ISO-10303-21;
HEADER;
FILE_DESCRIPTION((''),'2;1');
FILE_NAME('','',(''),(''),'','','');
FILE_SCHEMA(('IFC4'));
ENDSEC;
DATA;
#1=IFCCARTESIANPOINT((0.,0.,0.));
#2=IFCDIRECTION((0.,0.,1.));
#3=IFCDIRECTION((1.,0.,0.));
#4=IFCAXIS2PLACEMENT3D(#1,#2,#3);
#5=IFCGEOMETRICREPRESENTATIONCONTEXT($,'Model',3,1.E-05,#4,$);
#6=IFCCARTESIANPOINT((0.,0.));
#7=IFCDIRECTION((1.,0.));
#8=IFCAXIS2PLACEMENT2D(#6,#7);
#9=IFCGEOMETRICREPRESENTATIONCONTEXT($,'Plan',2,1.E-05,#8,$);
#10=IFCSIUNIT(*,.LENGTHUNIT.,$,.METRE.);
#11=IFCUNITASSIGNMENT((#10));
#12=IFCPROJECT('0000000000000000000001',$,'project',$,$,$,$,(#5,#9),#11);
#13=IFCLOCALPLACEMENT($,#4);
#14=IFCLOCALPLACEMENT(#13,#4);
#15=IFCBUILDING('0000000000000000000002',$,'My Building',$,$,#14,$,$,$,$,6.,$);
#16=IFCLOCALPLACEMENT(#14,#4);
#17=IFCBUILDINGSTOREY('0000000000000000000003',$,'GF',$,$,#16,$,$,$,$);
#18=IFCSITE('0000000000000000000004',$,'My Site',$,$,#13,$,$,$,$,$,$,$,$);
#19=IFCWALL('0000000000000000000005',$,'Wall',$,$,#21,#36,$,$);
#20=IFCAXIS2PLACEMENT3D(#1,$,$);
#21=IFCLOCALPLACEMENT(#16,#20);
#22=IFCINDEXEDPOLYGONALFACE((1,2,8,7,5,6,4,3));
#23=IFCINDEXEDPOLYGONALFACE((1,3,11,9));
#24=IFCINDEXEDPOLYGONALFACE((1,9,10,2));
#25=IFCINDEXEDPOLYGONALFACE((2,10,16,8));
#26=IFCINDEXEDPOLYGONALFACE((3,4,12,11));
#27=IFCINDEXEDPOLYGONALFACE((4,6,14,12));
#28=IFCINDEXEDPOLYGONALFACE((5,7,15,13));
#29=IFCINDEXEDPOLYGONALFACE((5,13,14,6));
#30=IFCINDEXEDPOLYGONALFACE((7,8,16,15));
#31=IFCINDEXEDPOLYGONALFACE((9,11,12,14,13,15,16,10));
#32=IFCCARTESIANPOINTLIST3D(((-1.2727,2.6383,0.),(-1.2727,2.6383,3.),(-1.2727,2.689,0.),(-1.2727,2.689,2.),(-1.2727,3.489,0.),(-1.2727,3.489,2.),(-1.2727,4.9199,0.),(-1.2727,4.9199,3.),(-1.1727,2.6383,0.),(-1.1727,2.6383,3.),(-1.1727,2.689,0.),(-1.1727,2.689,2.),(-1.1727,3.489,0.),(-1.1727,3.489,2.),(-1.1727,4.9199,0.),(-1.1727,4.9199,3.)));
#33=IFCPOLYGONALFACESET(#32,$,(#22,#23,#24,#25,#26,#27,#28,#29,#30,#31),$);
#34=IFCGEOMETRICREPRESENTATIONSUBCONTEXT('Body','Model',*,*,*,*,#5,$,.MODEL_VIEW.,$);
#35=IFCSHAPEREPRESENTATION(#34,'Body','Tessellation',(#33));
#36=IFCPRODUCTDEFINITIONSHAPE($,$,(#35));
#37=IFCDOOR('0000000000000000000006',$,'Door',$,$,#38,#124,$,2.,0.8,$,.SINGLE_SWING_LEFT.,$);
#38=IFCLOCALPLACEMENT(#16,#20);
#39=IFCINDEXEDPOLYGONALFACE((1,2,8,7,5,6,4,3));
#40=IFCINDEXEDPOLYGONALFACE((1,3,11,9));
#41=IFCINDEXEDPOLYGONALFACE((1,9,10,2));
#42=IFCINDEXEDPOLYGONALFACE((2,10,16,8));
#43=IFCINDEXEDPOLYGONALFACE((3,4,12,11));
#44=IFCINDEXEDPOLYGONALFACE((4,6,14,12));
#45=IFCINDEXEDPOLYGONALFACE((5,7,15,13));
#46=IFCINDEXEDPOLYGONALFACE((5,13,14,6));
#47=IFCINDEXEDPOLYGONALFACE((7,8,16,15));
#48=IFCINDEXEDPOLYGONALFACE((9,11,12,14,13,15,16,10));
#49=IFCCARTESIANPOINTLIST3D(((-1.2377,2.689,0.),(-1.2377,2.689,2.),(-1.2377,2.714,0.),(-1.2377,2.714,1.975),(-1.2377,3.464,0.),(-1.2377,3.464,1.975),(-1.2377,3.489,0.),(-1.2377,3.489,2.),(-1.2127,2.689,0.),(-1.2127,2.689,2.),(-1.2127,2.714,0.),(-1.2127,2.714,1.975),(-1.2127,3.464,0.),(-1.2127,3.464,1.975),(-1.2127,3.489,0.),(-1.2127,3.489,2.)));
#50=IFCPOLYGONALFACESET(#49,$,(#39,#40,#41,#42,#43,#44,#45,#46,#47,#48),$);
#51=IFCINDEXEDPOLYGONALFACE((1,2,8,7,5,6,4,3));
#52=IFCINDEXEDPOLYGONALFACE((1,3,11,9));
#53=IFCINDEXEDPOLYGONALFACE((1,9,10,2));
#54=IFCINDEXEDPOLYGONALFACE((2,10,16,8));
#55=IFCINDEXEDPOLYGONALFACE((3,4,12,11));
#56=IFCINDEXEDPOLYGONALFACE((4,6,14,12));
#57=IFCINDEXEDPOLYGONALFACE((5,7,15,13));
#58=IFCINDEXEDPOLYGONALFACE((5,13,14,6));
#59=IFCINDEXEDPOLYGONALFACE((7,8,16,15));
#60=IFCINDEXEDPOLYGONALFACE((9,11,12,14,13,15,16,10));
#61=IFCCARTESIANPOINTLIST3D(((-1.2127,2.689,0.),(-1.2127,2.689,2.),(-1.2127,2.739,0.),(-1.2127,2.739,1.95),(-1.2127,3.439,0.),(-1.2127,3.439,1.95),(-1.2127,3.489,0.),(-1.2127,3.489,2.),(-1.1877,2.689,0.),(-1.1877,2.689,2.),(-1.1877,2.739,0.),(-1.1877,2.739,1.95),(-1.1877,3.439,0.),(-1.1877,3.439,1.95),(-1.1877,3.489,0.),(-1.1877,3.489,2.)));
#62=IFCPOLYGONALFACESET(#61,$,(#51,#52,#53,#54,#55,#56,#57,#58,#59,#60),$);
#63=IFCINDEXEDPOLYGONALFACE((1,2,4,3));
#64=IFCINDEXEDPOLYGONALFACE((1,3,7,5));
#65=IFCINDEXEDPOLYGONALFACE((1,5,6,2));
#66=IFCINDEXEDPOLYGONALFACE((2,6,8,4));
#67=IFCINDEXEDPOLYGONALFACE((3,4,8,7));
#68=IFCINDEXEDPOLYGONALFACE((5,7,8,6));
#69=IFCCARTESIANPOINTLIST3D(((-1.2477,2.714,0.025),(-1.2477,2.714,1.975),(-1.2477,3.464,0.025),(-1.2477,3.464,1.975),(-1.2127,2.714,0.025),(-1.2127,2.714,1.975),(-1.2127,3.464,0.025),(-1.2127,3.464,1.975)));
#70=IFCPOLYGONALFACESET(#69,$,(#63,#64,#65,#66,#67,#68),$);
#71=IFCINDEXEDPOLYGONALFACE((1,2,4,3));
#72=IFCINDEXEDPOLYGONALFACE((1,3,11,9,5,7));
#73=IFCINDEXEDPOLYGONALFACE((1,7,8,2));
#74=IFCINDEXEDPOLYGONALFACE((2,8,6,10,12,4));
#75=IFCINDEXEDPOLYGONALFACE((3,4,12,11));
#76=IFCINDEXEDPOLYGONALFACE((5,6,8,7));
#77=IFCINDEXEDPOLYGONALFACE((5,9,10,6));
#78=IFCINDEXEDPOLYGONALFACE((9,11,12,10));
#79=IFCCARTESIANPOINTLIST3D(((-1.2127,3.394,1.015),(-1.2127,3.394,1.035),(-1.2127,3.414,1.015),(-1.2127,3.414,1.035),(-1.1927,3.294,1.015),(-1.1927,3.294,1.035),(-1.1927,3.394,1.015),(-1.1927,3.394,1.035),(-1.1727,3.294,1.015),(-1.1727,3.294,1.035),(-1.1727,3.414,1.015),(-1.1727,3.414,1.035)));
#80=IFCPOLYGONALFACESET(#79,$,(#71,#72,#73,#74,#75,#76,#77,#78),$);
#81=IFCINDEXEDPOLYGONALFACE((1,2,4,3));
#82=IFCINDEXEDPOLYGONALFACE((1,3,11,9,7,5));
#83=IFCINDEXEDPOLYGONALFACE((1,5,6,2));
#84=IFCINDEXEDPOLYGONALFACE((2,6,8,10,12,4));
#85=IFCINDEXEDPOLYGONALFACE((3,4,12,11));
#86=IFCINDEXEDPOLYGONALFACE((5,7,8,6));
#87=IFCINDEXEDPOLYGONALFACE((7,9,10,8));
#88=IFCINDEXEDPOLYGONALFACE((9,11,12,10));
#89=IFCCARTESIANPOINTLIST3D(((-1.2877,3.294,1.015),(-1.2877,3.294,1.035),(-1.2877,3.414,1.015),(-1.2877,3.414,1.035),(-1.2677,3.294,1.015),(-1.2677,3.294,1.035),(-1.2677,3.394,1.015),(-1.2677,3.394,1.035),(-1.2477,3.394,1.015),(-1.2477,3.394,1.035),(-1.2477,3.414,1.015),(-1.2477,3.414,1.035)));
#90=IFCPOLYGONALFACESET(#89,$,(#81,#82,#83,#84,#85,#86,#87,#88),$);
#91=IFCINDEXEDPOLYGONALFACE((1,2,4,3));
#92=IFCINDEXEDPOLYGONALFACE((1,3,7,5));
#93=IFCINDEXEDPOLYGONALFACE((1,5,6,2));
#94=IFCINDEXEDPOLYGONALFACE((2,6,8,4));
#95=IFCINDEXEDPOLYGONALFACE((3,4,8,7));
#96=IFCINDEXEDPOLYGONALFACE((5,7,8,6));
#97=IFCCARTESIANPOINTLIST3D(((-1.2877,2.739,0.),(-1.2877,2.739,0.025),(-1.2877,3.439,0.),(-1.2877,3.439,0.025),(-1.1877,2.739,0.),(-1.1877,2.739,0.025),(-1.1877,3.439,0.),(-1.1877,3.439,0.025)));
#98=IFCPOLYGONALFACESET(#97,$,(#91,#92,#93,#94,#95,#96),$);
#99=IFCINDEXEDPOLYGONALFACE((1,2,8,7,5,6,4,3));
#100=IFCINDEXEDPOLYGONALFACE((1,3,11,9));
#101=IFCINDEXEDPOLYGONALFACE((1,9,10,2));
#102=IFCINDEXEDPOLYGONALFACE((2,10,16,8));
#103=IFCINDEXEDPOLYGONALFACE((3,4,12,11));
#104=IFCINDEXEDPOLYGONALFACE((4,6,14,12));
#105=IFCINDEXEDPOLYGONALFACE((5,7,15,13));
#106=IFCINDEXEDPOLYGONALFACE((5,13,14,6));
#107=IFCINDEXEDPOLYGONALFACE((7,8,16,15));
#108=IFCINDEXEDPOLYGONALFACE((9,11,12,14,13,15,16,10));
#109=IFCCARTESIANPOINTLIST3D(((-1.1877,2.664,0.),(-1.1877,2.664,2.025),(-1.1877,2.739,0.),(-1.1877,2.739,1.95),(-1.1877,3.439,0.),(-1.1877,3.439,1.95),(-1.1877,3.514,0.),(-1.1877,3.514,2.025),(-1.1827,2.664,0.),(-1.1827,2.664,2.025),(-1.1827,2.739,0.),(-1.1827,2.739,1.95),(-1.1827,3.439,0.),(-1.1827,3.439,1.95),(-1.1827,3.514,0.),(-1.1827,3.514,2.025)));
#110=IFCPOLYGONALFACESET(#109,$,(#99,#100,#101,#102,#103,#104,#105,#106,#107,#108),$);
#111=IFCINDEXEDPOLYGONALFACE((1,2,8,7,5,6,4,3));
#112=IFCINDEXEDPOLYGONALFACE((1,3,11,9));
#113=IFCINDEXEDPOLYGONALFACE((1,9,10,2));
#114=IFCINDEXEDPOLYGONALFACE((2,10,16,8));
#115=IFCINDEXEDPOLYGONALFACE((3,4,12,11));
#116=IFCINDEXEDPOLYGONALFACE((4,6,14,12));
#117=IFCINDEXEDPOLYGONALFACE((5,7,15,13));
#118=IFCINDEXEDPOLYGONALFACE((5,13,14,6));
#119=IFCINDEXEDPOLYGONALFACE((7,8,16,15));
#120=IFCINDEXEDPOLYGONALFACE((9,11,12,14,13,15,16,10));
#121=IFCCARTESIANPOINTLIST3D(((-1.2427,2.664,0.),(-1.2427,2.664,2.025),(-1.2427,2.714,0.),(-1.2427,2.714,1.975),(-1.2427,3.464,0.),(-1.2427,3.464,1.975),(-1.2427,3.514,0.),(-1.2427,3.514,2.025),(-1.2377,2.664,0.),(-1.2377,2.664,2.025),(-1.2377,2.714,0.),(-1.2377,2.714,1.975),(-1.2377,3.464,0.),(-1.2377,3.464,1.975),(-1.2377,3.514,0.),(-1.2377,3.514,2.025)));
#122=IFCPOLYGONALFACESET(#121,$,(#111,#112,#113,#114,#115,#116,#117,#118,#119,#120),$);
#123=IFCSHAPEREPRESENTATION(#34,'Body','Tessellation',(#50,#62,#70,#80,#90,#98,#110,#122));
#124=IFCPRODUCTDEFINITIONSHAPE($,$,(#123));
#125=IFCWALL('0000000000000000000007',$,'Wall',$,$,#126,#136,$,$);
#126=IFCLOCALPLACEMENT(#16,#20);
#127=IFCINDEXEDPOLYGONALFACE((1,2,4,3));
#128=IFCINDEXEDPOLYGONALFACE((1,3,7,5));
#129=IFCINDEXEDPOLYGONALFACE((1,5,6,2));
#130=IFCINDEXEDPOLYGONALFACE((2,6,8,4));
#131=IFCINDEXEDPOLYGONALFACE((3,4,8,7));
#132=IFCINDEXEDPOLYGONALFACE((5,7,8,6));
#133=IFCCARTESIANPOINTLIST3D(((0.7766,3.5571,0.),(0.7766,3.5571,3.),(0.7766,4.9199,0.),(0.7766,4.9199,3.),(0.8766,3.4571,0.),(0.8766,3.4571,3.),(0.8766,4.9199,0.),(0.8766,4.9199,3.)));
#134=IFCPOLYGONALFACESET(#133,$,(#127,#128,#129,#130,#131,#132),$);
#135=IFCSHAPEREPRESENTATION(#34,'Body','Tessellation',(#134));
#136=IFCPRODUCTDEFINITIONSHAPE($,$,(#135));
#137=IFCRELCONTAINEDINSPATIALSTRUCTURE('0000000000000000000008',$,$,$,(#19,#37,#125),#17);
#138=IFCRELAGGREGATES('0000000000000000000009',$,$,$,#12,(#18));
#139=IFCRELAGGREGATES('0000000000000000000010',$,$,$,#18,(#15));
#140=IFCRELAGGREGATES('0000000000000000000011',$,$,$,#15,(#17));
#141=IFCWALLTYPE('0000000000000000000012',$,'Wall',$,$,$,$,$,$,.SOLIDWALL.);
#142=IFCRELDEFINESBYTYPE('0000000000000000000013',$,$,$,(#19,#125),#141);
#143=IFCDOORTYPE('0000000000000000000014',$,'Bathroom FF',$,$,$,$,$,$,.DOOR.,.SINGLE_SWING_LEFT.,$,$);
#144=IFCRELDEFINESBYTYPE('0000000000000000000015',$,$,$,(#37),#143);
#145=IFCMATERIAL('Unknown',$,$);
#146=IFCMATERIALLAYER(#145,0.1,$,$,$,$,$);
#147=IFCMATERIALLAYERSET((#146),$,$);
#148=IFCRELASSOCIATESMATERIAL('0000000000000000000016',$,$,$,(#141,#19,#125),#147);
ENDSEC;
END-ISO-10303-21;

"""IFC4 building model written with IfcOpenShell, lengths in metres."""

from ifc_helpers import new_model, entity, si_unit, frame, origin_with_axes, origin_2d_with_axis, place, context, subcontext, project, spatial, line, indexed_curve, outline, extrude, shape, source, transform, mapped, material, layer, layer_set, layer_usage, type_object, type_shapes, element, fill, save


model = new_model("IFC4")

# Units and contexts
model_context = context("Model", 3, precision=1e-05, world=origin_with_axes())
plan_context = context("Plan", 2, precision=1e-05, world=origin_2d_with_axis())
body_context_1 = subcontext(model_context, "Body", "Model", "MODEL_VIEW")
body_context_2 = subcontext(plan_context, "Body", "Plan", "PLAN_VIEW")
ifc_project = project(units=[si_unit("LENGTHUNIT", "METRE")], contexts=[model_context, plan_context])

# Site, building, storey
site_placement = place(None, origin_with_axes())
site = spatial("IfcSite", under=ifc_project, at=site_placement, Name="My Site")
building_placement = place(site_placement, origin_with_axes())
building = spatial("IfcBuilding", under=site, at=building_placement, Name="My Building", ElevationOfTerrain=6.0)
storey_placement = place(building_placement, origin_with_axes())
storey = spatial("IfcBuildingStorey", under=building, at=storey_placement, Name="GF")

# Shared definitions
ifc_material_1 = material(Name="Unknown")
ifc_layer = layer(ifc_material_1, 0.1)
ifc_layer_set = layer_set([ifc_layer])
wall_type = type_object("IfcWallType", Name="Wall", PredefinedType="SOLIDWALL", material=ifc_layer_set)

# Wall, opening, door
ifc_layer_usage_1 = layer_usage(ifc_layer_set, "AXIS2", "POSITIVE", 0.0)
wall_1_placement = place(storey_placement, frame((-1.1727, 2.6383, 0.0), z_axis=(0.0, 0.0, 1.0), x_axis=(0.0, 1.0, 0.0)))
wall_1 = element("IfcWall", 1, at=wall_1_placement, inside=storey, type_object=wall_type, material=ifc_layer_usage_1, Name="Wall", context=body_context_1, shape_type="SweptSolid", body=[
    extrude(outline(indexed_curve([(0.0, 0.0), (0.0, 0.1), (2.2816, 0.1), (2.2816, 0.0)], segments=[line(1, 2, 3, 4, 1)])), origin_with_axes(), (0.0, 0.0, 1.0), 3.0),
])
shared_shape_1 = source(origin_with_axes(), body_context_1, "Body", "SweptSolid", [
    extrude(outline(indexed_curve([(0.0, 0.0), (0.8, 0.0), (0.8, 2.0), (0.0, 2.0)], segments=[line(1, 2, 3, 4, 1)])), frame((0.0, -0.6, 0.0), z_axis=(0.0, -1.0, 0.0), x_axis=(1.0, 0.0, 0.0)), (0.0, 0.0, -1.0), 1.2),
])
opening_1_placement = place(wall_1_placement, frame((0.0507, 0.015, 0.0), z_axis=(0.0, 0.0, 1.0), x_axis=(1.0, 0.0, 0.0)))
opening_1 = element("IfcOpeningElement", 2, at=opening_1_placement, cuts=wall_1, PredefinedType="OPENING", context=body_context_1, shape_type="MappedRepresentation", body=[
    mapped(shared_shape_1, transform((0.0, 0.0, 0.0), x_axis=(1.0, 0.0, 0.0), y_axis=(0.0, 1.0, 0.0), z_axis=(0.0, 0.0, 1.0), scale=1.0)),
])
door_type_1 = type_object("IfcDoorType", Name="Bathroom FF", OperationType="SINGLE_SWING_LEFT", PredefinedType="DOOR")
shared_shape_2 = source(origin_with_axes(), body_context_1, "Body", "SweptSolid", [
    extrude(outline(indexed_curve([(0.0, 0.0), (0.0, 2.0), (0.8, 2.0), (0.8, 0.0), (0.775, 0.0), (0.775, 1.975), (0.025, 1.975), (0.025, 0.0)], segments=[line(1, 2, 3, 4, 5, 6, 7, 8, 1)])), frame((0.0, 0.025, 0.0), z_axis=(0.0, -1.0, 0.0), x_axis=(1.0, 0.0, 0.0)), (0.0, 0.0, -1.0), 0.025),
    extrude(outline(indexed_curve([(0.0, 0.0), (0.0, 2.0), (0.8, 2.0), (0.8, 0.0), (0.75, 0.0), (0.75, 1.95), (0.05, 1.95), (0.05, 0.0)], segments=[line(1, 2, 3, 4, 5, 6, 7, 8, 1)])), frame((0.0, 0.0, 0.0), z_axis=(0.0, -1.0, 0.0), x_axis=(1.0, 0.0, 0.0)), (0.0, 0.0, -1.0), 0.025),
    extrude(outline(indexed_curve([(0.0, 0.0), (0.75, 0.0), (0.75, 0.035), (0.0, 0.035)], segments=[line(1, 2, 3, 4, 1)])), frame((0.025, 0.025, 0.025), z_axis=(0.0, 0.0, 1.0), x_axis=(1.0, 0.0, 0.0)), (0.0, 0.0, 1.0), 1.95),
    extrude(outline(indexed_curve([(0.0, 0.0), (0.0, -0.04), (-0.12, -0.04), (-0.12, -0.02), (-0.02, -0.02), (-0.02, 0.0)], segments=[line(1, 2, 3, 4, 5, 6, 1)])), frame((0.725, 0.025, 1.015), z_axis=(0.0, 0.0, 1.0), x_axis=(1.0, 0.0, 0.0)), (0.0, 0.0, 1.0), 0.02),
    extrude(outline(indexed_curve([(0.0, 0.0), (0.0, 0.04), (-0.12, 0.04), (-0.12, 0.02), (-0.02, 0.02), (-0.02, 0.0)], segments=[line(1, 2, 3, 4, 5, 6, 1)])), frame((0.725, 0.06, 1.015), z_axis=(0.0, 0.0, 1.0), x_axis=(1.0, 0.0, 0.0)), (0.0, 0.0, 1.0), 0.02),
    extrude(outline(indexed_curve([(0.0, 0.0), (0.7, 0.0), (0.7, 0.1), (0.0, 0.1)], segments=[line(1, 2, 3, 4, 1)])), frame((0.05, 0.0, 0.0), z_axis=(0.0, 0.0, 1.0), x_axis=(1.0, 0.0, 0.0)), (0.0, 0.0, 1.0), 0.025),
    extrude(outline(indexed_curve([(0.0, 0.0), (0.0, 2.025), (0.85, 2.025), (0.85, 0.0), (0.775, 0.0), (0.775, 1.95), (0.075, 1.95), (0.075, 0.0)], segments=[line(1, 2, 3, 4, 5, 6, 7, 8, 1)])), frame((-0.025, -0.005, 0.0), z_axis=(0.0, -1.0, 0.0), x_axis=(1.0, 0.0, 0.0)), (0.0, 0.0, -1.0), 0.005),
    extrude(outline(indexed_curve([(0.0, 0.0), (0.0, 2.025), (0.85, 2.025), (0.85, 0.0), (0.8, 0.0), (0.8, 1.975), (0.05, 1.975), (0.05, 0.0)], segments=[line(1, 2, 3, 4, 5, 6, 7, 8, 1)])), frame((-0.025, 0.05, 0.0), z_axis=(0.0, -1.0, 0.0), x_axis=(1.0, 0.0, 0.0)), (0.0, 0.0, -1.0), 0.005),
])
shared_shape_3 = source(origin_with_axes(), body_context_2, "Body", "Curve2D", [
    entity("IfcIndexedPolyCurve", entity("IfcCartesianPointList2D", [[0.0, 0.0], [0.0, 0.05], [0.025, 0.05], [0.025, 0.025], [0.05, 0.025], [0.05, 0.0]]), [entity("IfcLineIndex", [1, 2, 3, 4, 5, 6, 1])]),
    entity("IfcIndexedPolyCurve", entity("IfcCartesianPointList2D", [[0.8, 0.0], [0.8, 0.05], [0.775, 0.05], [0.775, 0.025], [0.75, 0.025], [0.75, 0.0]]), [entity("IfcLineIndex", [1, 2, 3, 4, 5, 6, 1])]),
    entity("IfcTrimmedCurve", entity("IfcEllipse", entity("IfcAxis2Placement2D", entity("IfcCartesianPoint", [0.06, 0.05]), entity("IfcDirection", [1.0, 0.0])), 0.715, 0.75), [entity("IfcCartesianPoint", [0.775, 0.05])], [entity("IfcCartesianPoint", [0.06, 0.8])], True, "CARTESIAN"),
    entity("IfcIndexedPolyCurve", entity("IfcCartesianPointList2D", [[0.025, 0.05], [0.06, 0.05], [0.06, 0.8], [0.025, 0.8]]), [entity("IfcLineIndex", [1, 2, 3, 4, 1])]),
])
type_shapes(door_type_1, [shared_shape_2, shared_shape_3])
door_1_placement = place(opening_1_placement, frame((0.0, 0.0, 0.0), z_axis=(0.0, 0.0, 1.0), x_axis=(1.0, 0.0, 0.0)))
door_1 = element("IfcDoor", 3, at=door_1_placement, inside=storey, type_object=door_type_1, Name="Door", OperationType="SINGLE_SWING_LEFT", OverallHeight=2.0, OverallWidth=0.8, shapes=[
    shape(body_context_1, "Body", "MappedRepresentation", [mapped(shared_shape_2, transform((0.0, 0.0, 0.0), x_axis=(1.0, 0.0, 0.0), y_axis=(0.0, 1.0, 0.0), z_axis=(0.0, 0.0, 1.0), scale=1.0))]),
    shape(body_context_2, "Body", "MappedRepresentation", [mapped(shared_shape_3, transform((0.0, 0.0, 0.0), x_axis=(1.0, 0.0, 0.0), y_axis=(0.0, 1.0, 0.0), z_axis=(0.0, 0.0, 1.0), scale=1.0))]),
])
fill(opening_1, door_1)

# Wall
ifc_layer_usage_2 = layer_usage(ifc_layer_set, "AXIS2", "POSITIVE", 0.0)
wall_2_placement = place(storey_placement, frame((0.7766, 5.0199, 0.0), z_axis=(0.0, 0.0, 1.0), x_axis=(0.0, -1.0, 0.0)))
element("IfcWall", 4, at=wall_2_placement, inside=storey, type_object=wall_type, material=ifc_layer_usage_2, Name="Wall", context=body_context_1, shape_type="SweptSolid", body=[
    extrude(outline(indexed_curve([(0.1, 0.0), (0.1, 0.1), (1.5628, 0.1), (1.4628, 0.0)], segments=[line(1, 2, 3, 4, 1)])), origin_with_axes(), (0.0, 0.0, 1.0), 3.0),
])

save(model, "model.ifc")
